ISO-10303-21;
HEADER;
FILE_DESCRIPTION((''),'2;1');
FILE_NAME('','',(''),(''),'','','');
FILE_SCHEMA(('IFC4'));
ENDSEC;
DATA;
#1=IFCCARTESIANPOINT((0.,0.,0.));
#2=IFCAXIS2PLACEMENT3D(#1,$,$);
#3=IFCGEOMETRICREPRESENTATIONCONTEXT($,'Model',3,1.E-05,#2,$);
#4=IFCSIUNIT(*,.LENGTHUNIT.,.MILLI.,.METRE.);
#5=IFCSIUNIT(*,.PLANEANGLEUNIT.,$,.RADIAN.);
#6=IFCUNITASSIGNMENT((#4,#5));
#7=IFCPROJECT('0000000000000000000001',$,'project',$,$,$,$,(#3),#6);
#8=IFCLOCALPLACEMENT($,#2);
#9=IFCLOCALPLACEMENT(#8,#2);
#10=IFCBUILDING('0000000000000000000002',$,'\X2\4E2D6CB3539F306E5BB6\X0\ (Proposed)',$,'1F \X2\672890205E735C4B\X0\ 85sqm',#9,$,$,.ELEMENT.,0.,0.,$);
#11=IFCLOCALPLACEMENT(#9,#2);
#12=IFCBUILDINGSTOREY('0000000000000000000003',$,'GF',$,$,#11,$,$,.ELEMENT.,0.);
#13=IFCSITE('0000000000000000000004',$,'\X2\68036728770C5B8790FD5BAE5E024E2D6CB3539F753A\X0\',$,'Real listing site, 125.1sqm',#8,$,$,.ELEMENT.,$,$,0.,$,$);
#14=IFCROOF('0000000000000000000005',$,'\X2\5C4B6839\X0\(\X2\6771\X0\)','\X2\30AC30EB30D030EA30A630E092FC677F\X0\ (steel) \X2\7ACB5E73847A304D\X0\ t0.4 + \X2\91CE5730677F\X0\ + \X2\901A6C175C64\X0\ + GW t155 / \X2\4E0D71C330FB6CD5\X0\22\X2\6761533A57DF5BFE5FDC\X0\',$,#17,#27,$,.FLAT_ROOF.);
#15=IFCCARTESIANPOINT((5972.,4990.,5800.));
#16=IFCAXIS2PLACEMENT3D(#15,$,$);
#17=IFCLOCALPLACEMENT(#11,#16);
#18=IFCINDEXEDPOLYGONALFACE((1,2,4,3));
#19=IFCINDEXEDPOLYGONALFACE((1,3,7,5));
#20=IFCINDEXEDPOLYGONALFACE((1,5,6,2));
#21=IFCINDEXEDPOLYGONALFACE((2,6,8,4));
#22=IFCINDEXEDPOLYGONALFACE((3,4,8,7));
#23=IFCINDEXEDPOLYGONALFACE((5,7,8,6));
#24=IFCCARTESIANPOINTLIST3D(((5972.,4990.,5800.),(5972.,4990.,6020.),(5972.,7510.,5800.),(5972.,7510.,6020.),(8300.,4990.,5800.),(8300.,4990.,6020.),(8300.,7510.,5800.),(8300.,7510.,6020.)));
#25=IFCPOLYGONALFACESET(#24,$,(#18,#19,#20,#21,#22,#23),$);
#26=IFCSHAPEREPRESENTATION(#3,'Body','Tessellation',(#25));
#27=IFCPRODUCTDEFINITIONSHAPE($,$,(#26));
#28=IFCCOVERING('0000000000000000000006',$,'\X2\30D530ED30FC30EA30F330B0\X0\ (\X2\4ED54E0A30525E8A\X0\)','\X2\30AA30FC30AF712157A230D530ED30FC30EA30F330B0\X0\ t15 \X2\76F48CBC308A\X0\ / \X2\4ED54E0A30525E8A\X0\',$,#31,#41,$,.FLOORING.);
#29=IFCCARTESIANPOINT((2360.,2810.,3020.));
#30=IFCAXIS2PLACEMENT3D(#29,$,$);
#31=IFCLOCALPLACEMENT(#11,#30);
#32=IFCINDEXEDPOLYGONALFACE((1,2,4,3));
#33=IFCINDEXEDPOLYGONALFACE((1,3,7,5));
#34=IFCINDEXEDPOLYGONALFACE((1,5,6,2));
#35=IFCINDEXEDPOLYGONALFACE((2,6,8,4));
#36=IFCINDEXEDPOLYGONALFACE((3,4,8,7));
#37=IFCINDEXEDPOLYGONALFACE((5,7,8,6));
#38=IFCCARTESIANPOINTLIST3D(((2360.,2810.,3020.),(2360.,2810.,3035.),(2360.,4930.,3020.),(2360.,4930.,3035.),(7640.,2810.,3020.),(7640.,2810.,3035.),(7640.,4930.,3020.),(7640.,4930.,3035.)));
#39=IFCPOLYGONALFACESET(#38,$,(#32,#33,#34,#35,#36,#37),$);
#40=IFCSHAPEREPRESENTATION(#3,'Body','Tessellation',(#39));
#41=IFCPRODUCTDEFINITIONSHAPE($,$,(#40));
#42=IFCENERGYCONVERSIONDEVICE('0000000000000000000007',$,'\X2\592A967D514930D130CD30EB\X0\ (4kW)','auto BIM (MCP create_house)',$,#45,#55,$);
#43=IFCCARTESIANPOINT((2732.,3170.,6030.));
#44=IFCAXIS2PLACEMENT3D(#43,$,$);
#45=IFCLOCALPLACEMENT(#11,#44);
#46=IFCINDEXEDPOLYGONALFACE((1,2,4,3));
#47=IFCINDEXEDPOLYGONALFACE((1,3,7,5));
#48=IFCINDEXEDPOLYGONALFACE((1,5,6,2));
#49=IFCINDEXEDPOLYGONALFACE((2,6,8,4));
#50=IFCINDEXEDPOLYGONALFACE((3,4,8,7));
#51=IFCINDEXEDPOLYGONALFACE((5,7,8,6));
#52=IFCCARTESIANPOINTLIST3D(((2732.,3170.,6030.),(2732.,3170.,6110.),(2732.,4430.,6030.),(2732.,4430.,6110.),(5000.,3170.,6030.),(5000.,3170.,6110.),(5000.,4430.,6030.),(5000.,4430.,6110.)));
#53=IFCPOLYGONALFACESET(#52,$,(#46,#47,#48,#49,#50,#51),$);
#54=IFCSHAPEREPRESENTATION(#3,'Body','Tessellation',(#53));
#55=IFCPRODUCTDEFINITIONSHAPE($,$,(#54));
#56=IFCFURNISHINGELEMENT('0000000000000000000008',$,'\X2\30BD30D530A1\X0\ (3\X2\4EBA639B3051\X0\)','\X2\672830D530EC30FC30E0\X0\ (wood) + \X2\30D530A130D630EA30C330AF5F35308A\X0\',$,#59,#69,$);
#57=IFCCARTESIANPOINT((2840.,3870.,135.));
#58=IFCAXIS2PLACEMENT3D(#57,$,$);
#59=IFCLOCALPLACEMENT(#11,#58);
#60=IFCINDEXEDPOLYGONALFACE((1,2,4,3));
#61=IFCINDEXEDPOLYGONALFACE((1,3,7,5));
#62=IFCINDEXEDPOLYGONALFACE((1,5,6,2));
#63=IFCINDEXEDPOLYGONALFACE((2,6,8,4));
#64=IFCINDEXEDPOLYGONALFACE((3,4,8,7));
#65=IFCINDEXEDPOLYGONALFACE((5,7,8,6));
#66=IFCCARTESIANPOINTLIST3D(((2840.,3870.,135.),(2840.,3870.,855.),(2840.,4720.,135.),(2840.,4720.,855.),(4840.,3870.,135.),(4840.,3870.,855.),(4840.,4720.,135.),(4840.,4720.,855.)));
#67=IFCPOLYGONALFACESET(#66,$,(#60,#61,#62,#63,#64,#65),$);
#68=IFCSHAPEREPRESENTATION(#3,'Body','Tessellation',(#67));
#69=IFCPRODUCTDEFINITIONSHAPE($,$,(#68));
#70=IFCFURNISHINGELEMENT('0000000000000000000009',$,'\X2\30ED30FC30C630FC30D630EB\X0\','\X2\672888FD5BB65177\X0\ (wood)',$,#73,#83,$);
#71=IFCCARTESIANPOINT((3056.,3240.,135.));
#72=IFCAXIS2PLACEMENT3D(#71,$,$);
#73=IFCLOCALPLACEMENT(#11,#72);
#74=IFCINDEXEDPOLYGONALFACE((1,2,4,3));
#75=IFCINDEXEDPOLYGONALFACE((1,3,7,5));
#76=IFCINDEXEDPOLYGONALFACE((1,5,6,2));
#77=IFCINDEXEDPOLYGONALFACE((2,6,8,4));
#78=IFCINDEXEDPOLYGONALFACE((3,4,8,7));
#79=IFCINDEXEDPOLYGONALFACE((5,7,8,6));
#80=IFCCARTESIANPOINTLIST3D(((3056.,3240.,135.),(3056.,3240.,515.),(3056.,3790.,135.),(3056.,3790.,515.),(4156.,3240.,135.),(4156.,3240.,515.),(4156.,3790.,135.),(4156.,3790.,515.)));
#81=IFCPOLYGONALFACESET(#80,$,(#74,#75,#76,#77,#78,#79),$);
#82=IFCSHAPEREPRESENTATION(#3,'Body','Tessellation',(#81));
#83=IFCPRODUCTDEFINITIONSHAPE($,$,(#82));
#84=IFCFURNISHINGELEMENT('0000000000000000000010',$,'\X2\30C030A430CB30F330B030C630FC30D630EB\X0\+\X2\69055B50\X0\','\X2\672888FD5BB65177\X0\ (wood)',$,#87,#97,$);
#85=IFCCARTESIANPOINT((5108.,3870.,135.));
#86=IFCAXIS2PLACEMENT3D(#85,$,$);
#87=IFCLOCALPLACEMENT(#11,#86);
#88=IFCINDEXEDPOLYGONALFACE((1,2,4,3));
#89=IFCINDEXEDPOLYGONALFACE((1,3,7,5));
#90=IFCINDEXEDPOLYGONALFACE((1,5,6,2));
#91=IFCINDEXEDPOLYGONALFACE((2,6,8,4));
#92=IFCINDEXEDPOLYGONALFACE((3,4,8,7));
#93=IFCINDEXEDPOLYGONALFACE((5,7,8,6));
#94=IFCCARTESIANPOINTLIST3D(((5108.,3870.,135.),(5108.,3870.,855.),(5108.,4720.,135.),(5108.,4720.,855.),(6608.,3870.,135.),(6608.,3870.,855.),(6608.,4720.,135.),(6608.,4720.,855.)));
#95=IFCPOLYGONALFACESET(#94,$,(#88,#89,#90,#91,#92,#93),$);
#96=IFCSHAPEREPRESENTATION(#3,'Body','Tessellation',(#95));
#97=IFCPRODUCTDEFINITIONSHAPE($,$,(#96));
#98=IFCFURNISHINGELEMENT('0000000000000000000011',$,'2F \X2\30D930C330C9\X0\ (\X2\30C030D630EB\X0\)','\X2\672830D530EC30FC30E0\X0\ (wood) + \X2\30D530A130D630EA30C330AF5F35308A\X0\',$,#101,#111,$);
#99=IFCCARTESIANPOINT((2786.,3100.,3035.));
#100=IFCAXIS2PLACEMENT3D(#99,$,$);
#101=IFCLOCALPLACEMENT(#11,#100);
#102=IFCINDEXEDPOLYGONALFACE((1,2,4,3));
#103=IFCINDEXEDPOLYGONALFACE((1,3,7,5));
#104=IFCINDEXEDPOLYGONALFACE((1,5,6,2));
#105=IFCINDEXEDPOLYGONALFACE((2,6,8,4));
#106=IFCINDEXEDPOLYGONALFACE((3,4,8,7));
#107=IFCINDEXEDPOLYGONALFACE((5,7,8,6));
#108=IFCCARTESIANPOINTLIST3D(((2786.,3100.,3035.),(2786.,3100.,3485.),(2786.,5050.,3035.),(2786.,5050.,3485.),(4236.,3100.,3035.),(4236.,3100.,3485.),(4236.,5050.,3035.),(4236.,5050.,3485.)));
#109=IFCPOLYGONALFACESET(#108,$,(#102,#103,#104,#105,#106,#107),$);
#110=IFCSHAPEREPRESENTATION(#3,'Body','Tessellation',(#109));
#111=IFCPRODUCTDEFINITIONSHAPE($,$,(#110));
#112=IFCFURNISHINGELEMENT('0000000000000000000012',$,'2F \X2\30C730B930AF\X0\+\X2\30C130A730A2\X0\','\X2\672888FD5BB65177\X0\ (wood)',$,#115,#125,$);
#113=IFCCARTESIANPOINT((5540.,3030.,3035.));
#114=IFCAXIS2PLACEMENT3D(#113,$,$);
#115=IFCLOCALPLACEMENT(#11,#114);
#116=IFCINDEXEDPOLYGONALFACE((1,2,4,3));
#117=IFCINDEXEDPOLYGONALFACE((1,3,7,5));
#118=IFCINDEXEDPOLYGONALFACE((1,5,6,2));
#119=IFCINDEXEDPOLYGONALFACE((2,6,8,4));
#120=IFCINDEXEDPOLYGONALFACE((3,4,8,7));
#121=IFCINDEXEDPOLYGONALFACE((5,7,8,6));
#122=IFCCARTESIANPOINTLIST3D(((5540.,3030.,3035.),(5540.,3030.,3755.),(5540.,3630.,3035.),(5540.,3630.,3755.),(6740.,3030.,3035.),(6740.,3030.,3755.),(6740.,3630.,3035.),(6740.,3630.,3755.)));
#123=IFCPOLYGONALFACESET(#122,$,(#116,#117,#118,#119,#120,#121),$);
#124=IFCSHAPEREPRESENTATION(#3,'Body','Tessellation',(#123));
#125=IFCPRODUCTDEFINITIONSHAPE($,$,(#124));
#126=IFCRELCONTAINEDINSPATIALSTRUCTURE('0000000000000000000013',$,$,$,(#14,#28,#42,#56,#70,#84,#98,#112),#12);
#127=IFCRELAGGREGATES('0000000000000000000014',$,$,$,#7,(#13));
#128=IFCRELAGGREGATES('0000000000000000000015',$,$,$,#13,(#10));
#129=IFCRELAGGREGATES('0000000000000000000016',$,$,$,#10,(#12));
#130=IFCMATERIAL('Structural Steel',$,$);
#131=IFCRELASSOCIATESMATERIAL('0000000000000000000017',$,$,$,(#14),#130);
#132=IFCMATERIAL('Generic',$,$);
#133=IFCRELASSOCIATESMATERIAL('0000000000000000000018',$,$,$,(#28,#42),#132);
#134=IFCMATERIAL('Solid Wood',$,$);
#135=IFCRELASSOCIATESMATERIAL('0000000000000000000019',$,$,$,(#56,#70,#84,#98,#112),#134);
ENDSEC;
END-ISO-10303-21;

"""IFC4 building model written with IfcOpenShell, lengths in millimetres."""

from ifc_helpers import new_model, si_unit, frame, frame_2d, origin, place, context, project, spatial, rectangle, extrude, material, element, save


model = new_model("IFC4")

# Units and contexts
model_context = context("Model", 3, precision=1e-05, world=origin())
ifc_project = project(units=[si_unit("LENGTHUNIT", "METRE", prefix="MILLI"), si_unit("PLANEANGLEUNIT", "RADIAN")], contexts=[model_context])

# Site, building, storey
site_placement = place(None, origin())
site = spatial("IfcSite", under=ifc_project, at=site_placement, Name="栃木県宇都宮市中河原町", ObjectType="Real listing site, 125.1sqm", CompositionType="ELEMENT", RefElevation=0.0)
building_placement = place(site_placement, origin())
building = spatial("IfcBuilding", under=site, at=building_placement, Name="中河原の家 (Proposed)", ObjectType="1F 木造平屋 85sqm", CompositionType="ELEMENT", ElevationOfRefHeight=0.0, ElevationOfTerrain=0.0)
storey_placement = place(building_placement, origin())
storey = spatial("IfcBuildingStorey", under=building, at=storey_placement, Name="GF", CompositionType="ELEMENT", Elevation=0.0)

# Shared definitions
ifc_material_1 = material(Name="Solid Wood")

# Roof
ifc_material_2 = material(Name="Structural Steel")
roof_1_placement = place(storey_placement, frame((5972.0, 4990.0, 5800.0)))
element("IfcRoof", 1, at=roof_1_placement, inside=storey, material=ifc_material_2, Name="屋根(東)", Description="ガルバリウム鋼板 (steel) 立平葺き t0.4 + 野地板 + 通気層 + GW t155 / 不燃・法22条区域対応", PredefinedType="FLAT_ROOF", context=model_context, shape_type="SweptSolid", body=[
    extrude(rectangle(XDim=2328.0, YDim=2520.0, at=frame_2d((1164.0, 1260.0))), frame((5972.0, 4990.0, 5800.0)), (0.0, 0.0, 1.0), 220.0),
])

# Covering
ifc_material_3 = material(Name="Generic")
covering_placement = place(storey_placement, frame((2360.0, 2810.0, 3020.0)))
element("IfcCovering", 2, at=covering_placement, inside=storey, material=ifc_material_3, Name="フローリング (仕上げ床)", Description="オーク無垢フローリング t15 直貼り / 仕上げ床", PredefinedType="FLOORING", context=model_context, shape_type="SweptSolid", body=[
    extrude(rectangle(XDim=5280.0, YDim=2120.0, at=frame_2d((2640.0, 1060.0))), frame((2360.0, 2810.0, 3020.0)), (0.0, 0.0, 1.0), 15.0),
])

# Energy conversion device
energy_conversion_device_placement = place(storey_placement, frame((2732.0, 3170.0, 6030.0)))
element("IfcEnergyConversionDevice", 3, at=energy_conversion_device_placement, inside=storey, material=ifc_material_3, Name="太陽光パネル (4kW)", Description="auto BIM (MCP create_house)", context=model_context, shape_type="SweptSolid", body=[
    extrude(rectangle(XDim=2268.0, YDim=1260.0, at=frame_2d((1134.0, 630.0))), frame((2732.0, 3170.0, 6030.0)), (0.0, 0.0, 1.0), 80.0),
])

# Furnishing elements
furnishing_1_placement = place(storey_placement, frame((2840.0, 3870.0, 135.0)))
element("IfcFurnishingElement", 4, at=furnishing_1_placement, inside=storey, material=ifc_material_1, Name="ソファ (3人掛け)", Description="木フレーム (wood) + ファブリック張り", context=model_context, shape_type="SweptSolid", body=[
    extrude(rectangle(XDim=2000.0, YDim=850.0, at=frame_2d((1000.0, 425.0))), frame((2840.0, 3870.0, 135.0)), (0.0, 0.0, 1.0), 720.0),
])
furnishing_2_placement = place(storey_placement, frame((3056.0, 3240.0, 135.0)))
element("IfcFurnishingElement", 5, at=furnishing_2_placement, inside=storey, material=ifc_material_1, Name="ローテーブル", Description="木製家具 (wood)", context=model_context, shape_type="SweptSolid", body=[
    extrude(rectangle(XDim=1100.0, YDim=550.0, at=frame_2d((550.0, 275.0))), frame((3056.0, 3240.0, 135.0)), (0.0, 0.0, 1.0), 380.0),
])
furnishing_3_placement = place(storey_placement, frame((5108.0, 3870.0, 135.0)))
element("IfcFurnishingElement", 6, at=furnishing_3_placement, inside=storey, material=ifc_material_1, Name="ダイニングテーブル+椅子", Description="木製家具 (wood)", context=model_context, shape_type="SweptSolid", body=[
    extrude(rectangle(XDim=1500.0, YDim=850.0, at=frame_2d((750.0, 425.0))), frame((5108.0, 3870.0, 135.0)), (0.0, 0.0, 1.0), 720.0),
])
furnishing_4_placement = place(storey_placement, frame((2786.0, 3100.0, 3035.0)))
element("IfcFurnishingElement", 7, at=furnishing_4_placement, inside=storey, material=ifc_material_1, Name="2F ベッド (ダブル)", Description="木フレーム (wood) + ファブリック張り", context=model_context, shape_type="SweptSolid", body=[
    extrude(rectangle(XDim=1450.0, YDim=1950.0, at=frame_2d((725.0, 975.0))), frame((2786.0, 3100.0, 3035.0)), (0.0, 0.0, 1.0), 450.0),
])
furnishing_5_placement = place(storey_placement, frame((5540.0, 3030.0, 3035.0)))
element("IfcFurnishingElement", 8, at=furnishing_5_placement, inside=storey, material=ifc_material_1, Name="2F デスク+チェア", Description="木製家具 (wood)", context=model_context, shape_type="SweptSolid", body=[
    extrude(rectangle(XDim=1200.0, YDim=600.0, at=frame_2d((600.0, 300.0))), frame((5540.0, 3030.0, 3035.0)), (0.0, 0.0, 1.0), 720.0),
])

save(model, "model.ifc")
